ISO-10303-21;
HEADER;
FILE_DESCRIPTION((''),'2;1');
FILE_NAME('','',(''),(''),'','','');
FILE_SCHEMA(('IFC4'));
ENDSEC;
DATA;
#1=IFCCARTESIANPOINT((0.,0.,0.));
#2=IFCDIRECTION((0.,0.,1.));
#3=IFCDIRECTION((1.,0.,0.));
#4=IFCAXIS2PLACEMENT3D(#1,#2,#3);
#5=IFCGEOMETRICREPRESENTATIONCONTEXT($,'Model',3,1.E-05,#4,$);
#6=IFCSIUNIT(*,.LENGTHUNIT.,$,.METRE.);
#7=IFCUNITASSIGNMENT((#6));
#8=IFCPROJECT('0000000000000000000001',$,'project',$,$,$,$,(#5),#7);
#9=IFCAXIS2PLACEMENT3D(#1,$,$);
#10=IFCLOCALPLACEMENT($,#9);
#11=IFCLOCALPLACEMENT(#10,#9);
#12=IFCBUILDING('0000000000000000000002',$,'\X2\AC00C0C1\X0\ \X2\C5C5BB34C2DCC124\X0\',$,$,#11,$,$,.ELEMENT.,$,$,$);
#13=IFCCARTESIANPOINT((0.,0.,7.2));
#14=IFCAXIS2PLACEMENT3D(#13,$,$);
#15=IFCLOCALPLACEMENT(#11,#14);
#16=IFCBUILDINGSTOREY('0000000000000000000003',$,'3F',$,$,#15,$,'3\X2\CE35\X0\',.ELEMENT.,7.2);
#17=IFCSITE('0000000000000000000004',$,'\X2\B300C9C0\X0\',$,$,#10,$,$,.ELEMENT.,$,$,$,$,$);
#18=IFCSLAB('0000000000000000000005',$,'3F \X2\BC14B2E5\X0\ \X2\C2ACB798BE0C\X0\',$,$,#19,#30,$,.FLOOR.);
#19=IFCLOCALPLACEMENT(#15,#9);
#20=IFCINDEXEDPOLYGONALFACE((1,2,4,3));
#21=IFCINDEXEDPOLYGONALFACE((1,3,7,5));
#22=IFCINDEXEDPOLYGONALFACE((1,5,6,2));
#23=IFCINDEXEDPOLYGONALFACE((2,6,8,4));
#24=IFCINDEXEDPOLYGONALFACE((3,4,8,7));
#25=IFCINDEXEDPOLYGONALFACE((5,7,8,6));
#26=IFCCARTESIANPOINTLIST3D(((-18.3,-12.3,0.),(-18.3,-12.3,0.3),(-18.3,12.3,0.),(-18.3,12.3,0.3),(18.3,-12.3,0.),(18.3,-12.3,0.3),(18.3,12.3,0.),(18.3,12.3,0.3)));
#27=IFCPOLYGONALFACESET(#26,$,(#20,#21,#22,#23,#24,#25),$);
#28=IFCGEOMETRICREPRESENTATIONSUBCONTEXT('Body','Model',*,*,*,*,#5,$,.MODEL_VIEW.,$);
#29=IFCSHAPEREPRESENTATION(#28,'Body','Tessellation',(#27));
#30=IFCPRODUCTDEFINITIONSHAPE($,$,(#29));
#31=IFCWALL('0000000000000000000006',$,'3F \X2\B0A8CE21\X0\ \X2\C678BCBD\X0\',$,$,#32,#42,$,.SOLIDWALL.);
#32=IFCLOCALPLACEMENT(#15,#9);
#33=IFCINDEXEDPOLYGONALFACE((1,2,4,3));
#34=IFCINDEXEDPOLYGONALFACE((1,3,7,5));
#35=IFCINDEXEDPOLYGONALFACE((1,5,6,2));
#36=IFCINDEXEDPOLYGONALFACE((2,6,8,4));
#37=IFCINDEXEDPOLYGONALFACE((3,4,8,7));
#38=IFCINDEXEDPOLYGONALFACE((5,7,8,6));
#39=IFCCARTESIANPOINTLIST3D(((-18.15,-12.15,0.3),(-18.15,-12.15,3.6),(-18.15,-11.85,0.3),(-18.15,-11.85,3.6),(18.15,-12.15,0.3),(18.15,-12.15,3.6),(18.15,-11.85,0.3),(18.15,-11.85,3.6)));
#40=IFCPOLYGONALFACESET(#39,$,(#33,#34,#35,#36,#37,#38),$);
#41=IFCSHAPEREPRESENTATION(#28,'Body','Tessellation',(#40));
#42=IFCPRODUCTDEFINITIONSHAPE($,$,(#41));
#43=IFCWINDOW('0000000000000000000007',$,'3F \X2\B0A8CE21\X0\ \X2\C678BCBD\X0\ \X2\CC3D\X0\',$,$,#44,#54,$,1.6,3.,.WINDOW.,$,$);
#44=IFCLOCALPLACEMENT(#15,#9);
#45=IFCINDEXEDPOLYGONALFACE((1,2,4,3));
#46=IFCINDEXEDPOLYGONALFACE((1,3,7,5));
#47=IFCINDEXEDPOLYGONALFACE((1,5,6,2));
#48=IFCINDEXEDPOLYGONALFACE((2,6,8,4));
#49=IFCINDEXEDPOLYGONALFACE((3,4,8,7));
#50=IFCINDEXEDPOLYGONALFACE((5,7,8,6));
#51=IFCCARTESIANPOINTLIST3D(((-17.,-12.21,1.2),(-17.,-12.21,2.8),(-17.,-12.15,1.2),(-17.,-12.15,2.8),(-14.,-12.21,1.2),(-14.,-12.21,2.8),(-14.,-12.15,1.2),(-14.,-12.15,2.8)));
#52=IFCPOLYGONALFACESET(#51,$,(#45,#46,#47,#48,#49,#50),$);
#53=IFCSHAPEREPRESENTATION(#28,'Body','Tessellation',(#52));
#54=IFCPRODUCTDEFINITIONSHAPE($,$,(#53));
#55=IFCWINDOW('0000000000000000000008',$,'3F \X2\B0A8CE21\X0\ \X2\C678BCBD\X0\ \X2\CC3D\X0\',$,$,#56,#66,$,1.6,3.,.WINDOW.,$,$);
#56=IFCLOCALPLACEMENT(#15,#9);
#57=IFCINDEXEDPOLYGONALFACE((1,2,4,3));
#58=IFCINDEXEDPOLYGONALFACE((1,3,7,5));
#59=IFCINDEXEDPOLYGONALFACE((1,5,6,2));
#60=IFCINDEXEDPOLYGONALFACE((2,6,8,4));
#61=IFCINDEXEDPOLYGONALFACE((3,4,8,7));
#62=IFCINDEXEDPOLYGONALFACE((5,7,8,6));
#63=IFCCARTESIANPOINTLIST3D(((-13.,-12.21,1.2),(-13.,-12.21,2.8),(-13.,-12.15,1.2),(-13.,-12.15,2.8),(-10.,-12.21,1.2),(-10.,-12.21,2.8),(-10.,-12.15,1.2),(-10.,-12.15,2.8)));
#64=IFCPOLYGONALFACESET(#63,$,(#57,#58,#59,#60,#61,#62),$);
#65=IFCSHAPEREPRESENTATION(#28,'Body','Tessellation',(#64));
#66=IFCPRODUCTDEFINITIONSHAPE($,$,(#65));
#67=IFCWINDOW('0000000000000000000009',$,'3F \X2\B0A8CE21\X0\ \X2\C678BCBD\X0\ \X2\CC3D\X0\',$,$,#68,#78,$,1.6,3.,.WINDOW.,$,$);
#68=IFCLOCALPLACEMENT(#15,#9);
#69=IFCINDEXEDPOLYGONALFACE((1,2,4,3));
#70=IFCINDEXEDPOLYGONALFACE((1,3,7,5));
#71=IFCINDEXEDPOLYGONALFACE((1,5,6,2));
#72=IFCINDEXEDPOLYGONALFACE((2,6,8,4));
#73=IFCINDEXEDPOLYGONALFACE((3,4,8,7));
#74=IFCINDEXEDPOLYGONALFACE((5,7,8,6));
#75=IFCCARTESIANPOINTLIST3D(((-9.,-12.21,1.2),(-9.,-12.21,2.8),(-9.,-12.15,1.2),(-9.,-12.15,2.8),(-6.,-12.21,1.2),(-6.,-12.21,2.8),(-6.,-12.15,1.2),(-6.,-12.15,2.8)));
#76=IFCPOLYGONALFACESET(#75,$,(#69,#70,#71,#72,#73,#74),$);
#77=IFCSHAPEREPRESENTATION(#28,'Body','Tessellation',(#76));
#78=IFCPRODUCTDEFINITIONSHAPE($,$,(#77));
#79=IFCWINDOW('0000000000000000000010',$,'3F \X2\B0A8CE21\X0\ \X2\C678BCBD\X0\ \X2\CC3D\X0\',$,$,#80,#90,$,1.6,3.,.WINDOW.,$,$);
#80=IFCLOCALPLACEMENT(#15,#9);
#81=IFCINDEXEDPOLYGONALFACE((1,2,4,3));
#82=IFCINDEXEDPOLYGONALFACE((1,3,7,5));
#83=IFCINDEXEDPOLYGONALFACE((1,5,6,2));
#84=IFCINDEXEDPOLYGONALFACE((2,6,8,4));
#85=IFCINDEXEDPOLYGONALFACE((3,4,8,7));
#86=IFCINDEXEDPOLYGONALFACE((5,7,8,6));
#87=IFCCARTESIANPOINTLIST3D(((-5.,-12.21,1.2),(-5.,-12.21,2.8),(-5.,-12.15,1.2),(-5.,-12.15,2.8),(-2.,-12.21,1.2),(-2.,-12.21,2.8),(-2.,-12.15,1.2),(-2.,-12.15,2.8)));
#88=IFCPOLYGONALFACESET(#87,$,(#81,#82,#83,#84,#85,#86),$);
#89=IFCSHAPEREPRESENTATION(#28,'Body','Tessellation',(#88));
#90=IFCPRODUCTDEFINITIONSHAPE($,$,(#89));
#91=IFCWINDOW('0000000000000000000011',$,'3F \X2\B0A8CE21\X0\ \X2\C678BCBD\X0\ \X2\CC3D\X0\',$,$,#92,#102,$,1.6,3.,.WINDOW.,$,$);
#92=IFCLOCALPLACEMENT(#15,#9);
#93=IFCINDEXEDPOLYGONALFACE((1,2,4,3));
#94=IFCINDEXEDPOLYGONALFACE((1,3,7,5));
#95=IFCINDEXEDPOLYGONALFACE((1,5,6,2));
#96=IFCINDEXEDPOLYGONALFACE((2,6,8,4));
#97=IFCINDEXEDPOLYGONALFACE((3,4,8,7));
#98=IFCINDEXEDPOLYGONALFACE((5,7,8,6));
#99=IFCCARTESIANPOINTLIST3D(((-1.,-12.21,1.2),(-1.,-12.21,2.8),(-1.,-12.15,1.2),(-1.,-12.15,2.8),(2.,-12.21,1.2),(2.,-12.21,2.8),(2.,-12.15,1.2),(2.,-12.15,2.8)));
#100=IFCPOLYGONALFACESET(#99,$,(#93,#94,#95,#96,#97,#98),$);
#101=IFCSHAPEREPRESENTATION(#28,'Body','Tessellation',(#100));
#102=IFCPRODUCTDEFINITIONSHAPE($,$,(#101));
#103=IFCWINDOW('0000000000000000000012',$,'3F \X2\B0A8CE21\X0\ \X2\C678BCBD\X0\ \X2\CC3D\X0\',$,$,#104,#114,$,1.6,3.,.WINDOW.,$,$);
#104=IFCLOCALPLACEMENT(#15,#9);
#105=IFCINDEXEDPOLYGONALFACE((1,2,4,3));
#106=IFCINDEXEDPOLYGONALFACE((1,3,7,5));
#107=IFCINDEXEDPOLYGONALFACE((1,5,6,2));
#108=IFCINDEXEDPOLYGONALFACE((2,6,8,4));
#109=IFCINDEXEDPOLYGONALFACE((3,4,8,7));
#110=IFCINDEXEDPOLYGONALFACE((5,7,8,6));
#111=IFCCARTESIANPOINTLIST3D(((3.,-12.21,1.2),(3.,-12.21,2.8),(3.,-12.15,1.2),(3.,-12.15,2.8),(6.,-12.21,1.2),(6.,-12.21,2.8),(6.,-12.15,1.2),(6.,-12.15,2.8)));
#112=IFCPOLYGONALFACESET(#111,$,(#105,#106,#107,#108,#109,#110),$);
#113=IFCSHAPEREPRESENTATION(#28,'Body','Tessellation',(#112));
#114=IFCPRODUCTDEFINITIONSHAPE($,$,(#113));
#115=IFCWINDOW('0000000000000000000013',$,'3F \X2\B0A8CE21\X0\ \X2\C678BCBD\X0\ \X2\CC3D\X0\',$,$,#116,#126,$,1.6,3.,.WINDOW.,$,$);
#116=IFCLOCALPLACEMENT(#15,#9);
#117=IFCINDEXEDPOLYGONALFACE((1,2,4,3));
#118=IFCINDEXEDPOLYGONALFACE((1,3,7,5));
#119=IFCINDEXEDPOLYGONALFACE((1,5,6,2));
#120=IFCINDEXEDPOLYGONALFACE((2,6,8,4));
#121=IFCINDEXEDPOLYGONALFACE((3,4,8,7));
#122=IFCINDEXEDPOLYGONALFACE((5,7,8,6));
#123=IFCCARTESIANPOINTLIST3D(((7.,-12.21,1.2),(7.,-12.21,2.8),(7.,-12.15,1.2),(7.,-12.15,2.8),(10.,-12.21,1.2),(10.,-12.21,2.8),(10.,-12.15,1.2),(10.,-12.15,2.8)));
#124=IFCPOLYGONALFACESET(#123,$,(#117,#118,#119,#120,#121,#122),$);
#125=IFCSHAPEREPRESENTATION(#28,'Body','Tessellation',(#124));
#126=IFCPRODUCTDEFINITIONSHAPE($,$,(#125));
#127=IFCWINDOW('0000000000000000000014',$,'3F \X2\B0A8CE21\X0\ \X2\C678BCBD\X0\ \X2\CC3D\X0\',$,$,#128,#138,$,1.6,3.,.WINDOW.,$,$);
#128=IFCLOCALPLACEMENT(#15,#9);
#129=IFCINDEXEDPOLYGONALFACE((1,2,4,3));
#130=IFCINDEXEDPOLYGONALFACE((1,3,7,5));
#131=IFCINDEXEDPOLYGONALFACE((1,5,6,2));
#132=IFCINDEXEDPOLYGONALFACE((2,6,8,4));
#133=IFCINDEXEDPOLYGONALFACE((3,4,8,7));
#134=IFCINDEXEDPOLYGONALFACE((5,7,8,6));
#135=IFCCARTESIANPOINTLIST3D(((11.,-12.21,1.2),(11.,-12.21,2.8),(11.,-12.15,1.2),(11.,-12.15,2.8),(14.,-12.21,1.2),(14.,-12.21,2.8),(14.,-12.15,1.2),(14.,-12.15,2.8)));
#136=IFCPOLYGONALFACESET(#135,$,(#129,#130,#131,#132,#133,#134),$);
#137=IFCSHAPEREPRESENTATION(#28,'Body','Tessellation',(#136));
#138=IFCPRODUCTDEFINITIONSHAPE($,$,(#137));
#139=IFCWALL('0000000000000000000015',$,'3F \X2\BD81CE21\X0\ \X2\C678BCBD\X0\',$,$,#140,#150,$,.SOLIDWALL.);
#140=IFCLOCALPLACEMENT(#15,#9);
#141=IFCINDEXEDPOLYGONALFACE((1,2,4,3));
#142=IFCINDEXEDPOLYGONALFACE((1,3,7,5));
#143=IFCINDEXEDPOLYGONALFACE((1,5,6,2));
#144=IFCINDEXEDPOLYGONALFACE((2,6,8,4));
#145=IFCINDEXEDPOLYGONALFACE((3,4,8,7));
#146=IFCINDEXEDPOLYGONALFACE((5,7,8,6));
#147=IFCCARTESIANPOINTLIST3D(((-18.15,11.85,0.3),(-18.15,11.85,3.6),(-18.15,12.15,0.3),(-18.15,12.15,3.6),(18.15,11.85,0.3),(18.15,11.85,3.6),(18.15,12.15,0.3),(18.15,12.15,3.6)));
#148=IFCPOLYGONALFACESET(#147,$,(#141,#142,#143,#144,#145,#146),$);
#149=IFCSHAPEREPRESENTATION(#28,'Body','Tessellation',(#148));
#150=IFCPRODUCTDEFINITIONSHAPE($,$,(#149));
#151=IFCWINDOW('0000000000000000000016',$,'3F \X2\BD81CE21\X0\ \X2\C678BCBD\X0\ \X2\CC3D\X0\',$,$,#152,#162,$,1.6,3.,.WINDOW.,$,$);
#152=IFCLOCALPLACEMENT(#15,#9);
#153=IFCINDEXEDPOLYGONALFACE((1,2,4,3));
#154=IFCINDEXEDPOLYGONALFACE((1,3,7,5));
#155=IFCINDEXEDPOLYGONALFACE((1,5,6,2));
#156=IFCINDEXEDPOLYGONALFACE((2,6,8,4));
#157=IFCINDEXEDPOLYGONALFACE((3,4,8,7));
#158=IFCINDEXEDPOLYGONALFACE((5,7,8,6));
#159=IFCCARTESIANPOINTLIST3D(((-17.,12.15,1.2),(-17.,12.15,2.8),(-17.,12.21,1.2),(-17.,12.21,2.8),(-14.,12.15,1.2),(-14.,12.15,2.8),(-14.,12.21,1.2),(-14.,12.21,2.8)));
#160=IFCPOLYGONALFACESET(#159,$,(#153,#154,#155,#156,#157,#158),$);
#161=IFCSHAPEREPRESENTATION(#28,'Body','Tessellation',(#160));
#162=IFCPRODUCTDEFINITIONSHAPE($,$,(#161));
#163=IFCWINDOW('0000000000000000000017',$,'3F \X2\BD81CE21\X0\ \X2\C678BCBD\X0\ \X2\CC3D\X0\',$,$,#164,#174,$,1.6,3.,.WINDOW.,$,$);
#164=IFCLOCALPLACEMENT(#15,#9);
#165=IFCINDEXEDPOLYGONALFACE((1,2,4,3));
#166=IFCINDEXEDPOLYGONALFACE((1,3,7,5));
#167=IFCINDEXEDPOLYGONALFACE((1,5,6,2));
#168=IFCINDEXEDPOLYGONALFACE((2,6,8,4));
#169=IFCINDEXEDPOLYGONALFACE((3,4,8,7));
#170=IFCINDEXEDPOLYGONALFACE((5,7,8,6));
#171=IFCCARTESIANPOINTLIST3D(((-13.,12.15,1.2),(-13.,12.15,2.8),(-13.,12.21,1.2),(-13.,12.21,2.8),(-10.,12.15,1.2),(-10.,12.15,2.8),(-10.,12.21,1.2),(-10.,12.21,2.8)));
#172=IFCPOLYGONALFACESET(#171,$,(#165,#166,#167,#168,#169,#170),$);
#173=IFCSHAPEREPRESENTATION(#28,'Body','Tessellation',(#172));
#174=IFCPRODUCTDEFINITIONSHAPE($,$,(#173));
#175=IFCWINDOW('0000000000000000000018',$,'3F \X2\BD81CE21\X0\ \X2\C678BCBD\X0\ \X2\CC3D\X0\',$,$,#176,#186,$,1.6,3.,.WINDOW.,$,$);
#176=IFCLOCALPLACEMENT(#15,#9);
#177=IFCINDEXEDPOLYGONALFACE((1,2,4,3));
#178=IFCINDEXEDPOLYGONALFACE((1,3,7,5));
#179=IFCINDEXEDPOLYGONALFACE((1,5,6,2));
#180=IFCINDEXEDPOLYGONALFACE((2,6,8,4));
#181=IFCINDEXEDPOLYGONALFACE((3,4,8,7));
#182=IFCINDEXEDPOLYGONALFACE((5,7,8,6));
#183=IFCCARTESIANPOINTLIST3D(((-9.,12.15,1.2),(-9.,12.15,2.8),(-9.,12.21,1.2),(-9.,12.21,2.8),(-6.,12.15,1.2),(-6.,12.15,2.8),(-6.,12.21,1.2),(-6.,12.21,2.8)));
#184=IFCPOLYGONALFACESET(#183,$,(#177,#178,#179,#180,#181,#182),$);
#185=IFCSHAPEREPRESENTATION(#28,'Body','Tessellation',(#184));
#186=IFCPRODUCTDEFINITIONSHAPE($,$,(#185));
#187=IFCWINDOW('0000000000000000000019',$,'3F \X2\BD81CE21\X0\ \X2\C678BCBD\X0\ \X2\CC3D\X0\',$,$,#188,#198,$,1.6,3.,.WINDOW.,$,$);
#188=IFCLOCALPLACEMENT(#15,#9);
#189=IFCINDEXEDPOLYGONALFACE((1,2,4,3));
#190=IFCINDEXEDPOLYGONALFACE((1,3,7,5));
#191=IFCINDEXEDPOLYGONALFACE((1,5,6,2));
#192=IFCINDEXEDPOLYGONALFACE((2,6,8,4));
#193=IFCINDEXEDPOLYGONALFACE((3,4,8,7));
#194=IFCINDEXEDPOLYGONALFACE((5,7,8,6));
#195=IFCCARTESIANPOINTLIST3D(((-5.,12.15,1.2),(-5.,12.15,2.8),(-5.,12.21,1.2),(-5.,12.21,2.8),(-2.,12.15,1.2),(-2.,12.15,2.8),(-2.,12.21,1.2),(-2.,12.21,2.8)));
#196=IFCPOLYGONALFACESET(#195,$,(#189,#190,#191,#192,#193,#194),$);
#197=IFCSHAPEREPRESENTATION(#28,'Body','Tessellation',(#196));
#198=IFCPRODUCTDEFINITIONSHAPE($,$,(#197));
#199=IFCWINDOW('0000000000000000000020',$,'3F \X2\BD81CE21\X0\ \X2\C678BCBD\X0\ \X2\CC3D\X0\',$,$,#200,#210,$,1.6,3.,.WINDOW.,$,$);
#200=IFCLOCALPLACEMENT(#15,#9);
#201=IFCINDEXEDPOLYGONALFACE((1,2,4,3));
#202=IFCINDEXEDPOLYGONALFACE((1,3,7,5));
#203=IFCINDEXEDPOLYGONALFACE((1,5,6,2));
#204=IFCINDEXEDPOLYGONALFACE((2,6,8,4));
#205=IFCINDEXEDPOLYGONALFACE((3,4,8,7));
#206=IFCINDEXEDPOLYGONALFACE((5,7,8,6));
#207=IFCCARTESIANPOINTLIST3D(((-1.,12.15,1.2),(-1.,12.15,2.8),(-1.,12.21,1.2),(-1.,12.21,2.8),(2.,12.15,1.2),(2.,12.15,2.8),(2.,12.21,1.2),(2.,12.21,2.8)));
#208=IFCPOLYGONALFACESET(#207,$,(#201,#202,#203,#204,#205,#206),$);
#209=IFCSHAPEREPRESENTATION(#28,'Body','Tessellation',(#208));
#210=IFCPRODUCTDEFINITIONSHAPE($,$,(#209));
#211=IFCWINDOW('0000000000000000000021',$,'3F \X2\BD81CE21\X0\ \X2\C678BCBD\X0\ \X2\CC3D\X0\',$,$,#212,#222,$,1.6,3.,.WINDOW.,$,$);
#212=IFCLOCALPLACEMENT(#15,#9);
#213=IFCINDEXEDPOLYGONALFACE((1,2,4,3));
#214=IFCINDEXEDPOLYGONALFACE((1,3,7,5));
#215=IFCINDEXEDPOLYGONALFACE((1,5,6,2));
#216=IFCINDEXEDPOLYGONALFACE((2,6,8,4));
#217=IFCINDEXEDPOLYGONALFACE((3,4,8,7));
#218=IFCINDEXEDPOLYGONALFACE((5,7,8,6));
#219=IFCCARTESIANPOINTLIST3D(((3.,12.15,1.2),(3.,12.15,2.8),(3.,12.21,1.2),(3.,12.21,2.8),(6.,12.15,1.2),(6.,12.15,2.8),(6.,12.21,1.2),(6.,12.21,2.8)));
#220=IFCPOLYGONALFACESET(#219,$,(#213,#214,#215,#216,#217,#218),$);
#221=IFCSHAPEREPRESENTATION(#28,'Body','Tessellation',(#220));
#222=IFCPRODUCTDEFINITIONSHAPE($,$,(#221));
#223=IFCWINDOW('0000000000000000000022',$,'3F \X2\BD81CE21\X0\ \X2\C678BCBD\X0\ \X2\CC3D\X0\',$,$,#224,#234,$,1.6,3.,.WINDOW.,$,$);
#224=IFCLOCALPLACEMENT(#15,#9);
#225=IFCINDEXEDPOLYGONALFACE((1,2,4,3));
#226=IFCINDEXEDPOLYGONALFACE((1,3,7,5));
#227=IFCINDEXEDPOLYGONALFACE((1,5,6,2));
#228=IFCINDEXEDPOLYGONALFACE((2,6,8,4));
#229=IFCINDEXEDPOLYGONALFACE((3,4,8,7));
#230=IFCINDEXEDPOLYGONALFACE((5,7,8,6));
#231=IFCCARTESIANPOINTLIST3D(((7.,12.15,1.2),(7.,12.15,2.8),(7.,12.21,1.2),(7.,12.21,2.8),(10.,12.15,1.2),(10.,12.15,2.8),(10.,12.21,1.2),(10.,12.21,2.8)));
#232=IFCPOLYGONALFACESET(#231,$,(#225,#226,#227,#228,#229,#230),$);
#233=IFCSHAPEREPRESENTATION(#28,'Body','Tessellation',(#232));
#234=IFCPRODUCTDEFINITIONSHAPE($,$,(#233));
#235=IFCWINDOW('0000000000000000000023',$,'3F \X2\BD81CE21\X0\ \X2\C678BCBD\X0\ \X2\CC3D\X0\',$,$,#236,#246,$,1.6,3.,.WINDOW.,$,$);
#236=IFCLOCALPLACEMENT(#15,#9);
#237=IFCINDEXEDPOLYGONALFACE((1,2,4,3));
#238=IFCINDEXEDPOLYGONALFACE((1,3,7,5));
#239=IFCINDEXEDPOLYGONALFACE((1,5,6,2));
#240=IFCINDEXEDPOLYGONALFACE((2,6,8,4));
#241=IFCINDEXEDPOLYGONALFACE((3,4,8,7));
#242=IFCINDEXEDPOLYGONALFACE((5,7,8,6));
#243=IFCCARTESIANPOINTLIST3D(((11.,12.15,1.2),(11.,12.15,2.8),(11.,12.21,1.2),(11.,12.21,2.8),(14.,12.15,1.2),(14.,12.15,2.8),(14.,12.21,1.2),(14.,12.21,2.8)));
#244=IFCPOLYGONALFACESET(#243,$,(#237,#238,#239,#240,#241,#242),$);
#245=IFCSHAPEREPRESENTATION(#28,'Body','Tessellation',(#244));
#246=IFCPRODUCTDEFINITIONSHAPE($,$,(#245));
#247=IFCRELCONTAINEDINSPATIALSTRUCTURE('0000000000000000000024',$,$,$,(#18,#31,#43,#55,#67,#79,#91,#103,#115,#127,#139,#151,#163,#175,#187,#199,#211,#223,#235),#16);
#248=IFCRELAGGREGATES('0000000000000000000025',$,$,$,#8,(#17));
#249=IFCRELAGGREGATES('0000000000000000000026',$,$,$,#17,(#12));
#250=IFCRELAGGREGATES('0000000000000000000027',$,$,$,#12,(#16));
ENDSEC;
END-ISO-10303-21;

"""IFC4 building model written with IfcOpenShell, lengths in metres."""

from ifc_helpers import new_model, si_unit, frame, origin, origin_with_axes, origin_2d, place, context, subcontext, project, spatial, rectangle, extrude, element, save


model = new_model("IFC4")

# Units and contexts
model_context = context("Model", 3, precision=1e-05, world=origin_with_axes())
body_context = subcontext(model_context, "Body", "Model", "MODEL_VIEW")
ifc_project = project(units=[si_unit("LENGTHUNIT", "METRE")], contexts=[model_context])

# Site, building, storey
site_placement = place(None, origin())
site = spatial("IfcSite", under=ifc_project, at=site_placement, Name="대지", CompositionType="ELEMENT")
building_placement = place(site_placement, origin())
building = spatial("IfcBuilding", under=site, at=building_placement, Name="가상 업무시설", CompositionType="ELEMENT")
storey_placement = place(building_placement, frame((0.0, 0.0, 7.2)))
storey = spatial("IfcBuildingStorey", under=building, at=storey_placement, Name="3F", LongName="3층", CompositionType="ELEMENT", Elevation=7.2)

# Slab
slab_placement = place(storey_placement, origin())
element("IfcSlab", 1, at=slab_placement, inside=storey, Name="3F 바닥 슬래브", PredefinedType="FLOOR", context=body_context, shape_type="SweptSolid", body=[
    extrude(rectangle(XDim=36.6, YDim=24.6, at=origin_2d()), origin_with_axes(), (0.0, 0.0, 1.0), 0.3),
])

# Wall
wall_1_placement = place(storey_placement, frame((0.0, -12.0, 0.3)))
element("IfcWall", 2, at=wall_1_placement, inside=storey, Name="3F 남측 외벽", PredefinedType="SOLIDWALL", context=body_context, shape_type="SweptSolid", body=[
    extrude(rectangle(XDim=36.3, YDim=0.3, at=origin_2d()), origin_with_axes(), (0.0, 0.0, 1.0), 3.3),
])

# Windows
for number, where, name in (
    (3, (-15.5, -12.18, 1.2), "3F 남측 외벽 창"),
    (4, (-11.5, -12.18, 1.2), "3F 남측 외벽 창"),
    (5, (-7.5, -12.18, 1.2), "3F 남측 외벽 창"),
    (6, (-3.5, -12.18, 1.2), "3F 남측 외벽 창"),
    (7, (0.5, -12.18, 1.2), "3F 남측 외벽 창"),
    (8, (4.5, -12.18, 1.2), "3F 남측 외벽 창"),
    (9, (8.5, -12.18, 1.2), "3F 남측 외벽 창"),
    (10, (12.5, -12.18, 1.2), "3F 남측 외벽 창"),
):
    element("IfcWindow", number, at=place(storey_placement, frame(where)), inside=storey, Name=name, OverallHeight=1.6, OverallWidth=3.0, PredefinedType="WINDOW", context=body_context, shape_type="SweptSolid", body=[
        extrude(rectangle(XDim=3.0, YDim=0.06, at=origin_2d()), origin_with_axes(), (0.0, 0.0, 1.0), 1.6),
    ])

# Wall
wall_2_placement = place(storey_placement, frame((0.0, 12.0, 0.3)))
element("IfcWall", 11, at=wall_2_placement, inside=storey, Name="3F 북측 외벽", PredefinedType="SOLIDWALL", context=body_context, shape_type="SweptSolid", body=[
    extrude(rectangle(XDim=36.3, YDim=0.3, at=origin_2d()), origin_with_axes(), (0.0, 0.0, 1.0), 3.3),
])

# Windows
for number, where, name in (
    (12, (-15.5, 12.18, 1.2), "3F 북측 외벽 창"),
    (13, (-11.5, 12.18, 1.2), "3F 북측 외벽 창"),
    (14, (-7.5, 12.18, 1.2), "3F 북측 외벽 창"),
    (15, (-3.5, 12.18, 1.2), "3F 북측 외벽 창"),
    (16, (0.5, 12.18, 1.2), "3F 북측 외벽 창"),
    (17, (4.5, 12.18, 1.2), "3F 북측 외벽 창"),
    (18, (8.5, 12.18, 1.2), "3F 북측 외벽 창"),
    (19, (12.5, 12.18, 1.2), "3F 북측 외벽 창"),
):
    element("IfcWindow", number, at=place(storey_placement, frame(where)), inside=storey, Name=name, OverallHeight=1.6, OverallWidth=3.0, PredefinedType="WINDOW", context=body_context, shape_type="SweptSolid", body=[
        extrude(rectangle(XDim=3.0, YDim=0.06, at=origin_2d()), origin_with_axes(), (0.0, 0.0, 1.0), 1.6),
    ])

save(model, "model.ifc")
